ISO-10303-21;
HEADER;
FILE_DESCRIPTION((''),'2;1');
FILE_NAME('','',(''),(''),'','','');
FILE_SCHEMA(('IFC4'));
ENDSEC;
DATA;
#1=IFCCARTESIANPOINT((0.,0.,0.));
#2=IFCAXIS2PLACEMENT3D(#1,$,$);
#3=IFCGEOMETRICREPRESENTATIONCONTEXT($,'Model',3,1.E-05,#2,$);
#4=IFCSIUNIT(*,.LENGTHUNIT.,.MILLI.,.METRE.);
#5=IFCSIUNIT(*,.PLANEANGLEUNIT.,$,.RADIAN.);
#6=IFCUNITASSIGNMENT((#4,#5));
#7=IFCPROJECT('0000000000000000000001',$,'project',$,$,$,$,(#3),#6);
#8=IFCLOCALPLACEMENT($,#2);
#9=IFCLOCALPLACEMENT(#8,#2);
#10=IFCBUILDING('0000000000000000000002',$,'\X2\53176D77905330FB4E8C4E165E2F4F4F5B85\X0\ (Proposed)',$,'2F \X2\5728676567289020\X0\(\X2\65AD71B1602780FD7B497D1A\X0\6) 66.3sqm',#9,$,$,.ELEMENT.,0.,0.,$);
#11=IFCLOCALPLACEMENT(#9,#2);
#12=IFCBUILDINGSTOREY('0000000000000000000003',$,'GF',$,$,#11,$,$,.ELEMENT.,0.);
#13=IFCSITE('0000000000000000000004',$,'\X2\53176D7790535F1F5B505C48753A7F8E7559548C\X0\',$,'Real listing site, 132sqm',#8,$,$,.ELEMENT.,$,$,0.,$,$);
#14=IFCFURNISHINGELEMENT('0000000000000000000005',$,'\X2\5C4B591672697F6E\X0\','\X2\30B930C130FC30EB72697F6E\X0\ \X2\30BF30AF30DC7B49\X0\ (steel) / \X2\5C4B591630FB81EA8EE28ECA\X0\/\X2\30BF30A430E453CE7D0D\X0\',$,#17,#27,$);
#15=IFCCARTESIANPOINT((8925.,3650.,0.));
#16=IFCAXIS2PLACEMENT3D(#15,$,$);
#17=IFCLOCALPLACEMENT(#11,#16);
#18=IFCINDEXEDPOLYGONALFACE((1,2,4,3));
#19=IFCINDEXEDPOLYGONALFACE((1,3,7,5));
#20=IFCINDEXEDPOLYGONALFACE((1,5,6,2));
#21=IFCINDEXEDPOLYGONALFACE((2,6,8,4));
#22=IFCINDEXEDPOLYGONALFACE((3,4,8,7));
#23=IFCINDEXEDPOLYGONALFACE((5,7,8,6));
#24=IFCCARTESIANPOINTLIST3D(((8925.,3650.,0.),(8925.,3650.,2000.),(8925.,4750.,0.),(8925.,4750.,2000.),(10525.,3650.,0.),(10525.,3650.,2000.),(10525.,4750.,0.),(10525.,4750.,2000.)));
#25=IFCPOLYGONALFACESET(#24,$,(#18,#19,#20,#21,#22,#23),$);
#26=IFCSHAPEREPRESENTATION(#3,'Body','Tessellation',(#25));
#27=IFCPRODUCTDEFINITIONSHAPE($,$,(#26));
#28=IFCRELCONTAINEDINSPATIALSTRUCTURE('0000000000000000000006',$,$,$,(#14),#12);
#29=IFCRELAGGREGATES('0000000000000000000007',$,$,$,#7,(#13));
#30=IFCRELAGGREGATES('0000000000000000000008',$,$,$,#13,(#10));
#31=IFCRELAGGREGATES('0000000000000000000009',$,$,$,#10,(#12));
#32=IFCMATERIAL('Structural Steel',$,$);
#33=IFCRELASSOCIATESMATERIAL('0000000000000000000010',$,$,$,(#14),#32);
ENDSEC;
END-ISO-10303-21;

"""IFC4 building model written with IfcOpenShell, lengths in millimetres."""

from ifc_helpers import new_model, si_unit, frame, frame_2d, origin, place, context, project, spatial, rectangle, extrude, material, element, save


model = new_model("IFC4")

# Units and contexts
model_context = context("Model", 3, precision=1e-05, world=origin())
ifc_project = project(units=[si_unit("LENGTHUNIT", "METRE", prefix="MILLI"), si_unit("PLANEANGLEUNIT", "RADIAN")], contexts=[model_context])

# Site, building, storey
site_placement = place(None, origin())
site = spatial("IfcSite", under=ifc_project, at=site_placement, Name="北海道弟子屈町美留和", ObjectType="Real listing site, 132sqm", CompositionType="ELEMENT", RefElevation=0.0)
building_placement = place(site_placement, origin())
building = spatial("IfcBuilding", under=site, at=building_placement, Name="北海道・二世帯住宅 (Proposed)", ObjectType="2F 在来木造(断熱性能等級6) 66.3sqm", CompositionType="ELEMENT", ElevationOfRefHeight=0.0, ElevationOfTerrain=0.0)
storey_placement = place(building_placement, origin())
storey = spatial("IfcBuildingStorey", under=building, at=storey_placement, Name="GF", CompositionType="ELEMENT", Elevation=0.0)

# Shared definitions
ifc_material_1 = material(Name="Structural Steel")

# Furnishing element
furnishing_1_placement = place(storey_placement, frame((8925.0, 3650.0, 0.0)))
element("IfcFurnishingElement", 1, at=furnishing_1_placement, inside=storey, material=ifc_material_1, Name="屋外物置", Description="スチール物置 タクボ等 (steel) / 屋外・自転車/タイヤ収納", context=model_context, shape_type="SweptSolid", body=[
    extrude(rectangle(XDim=1600.0, YDim=1100.0, at=frame_2d((800.0, 550.0))), frame((8925.0, 3650.0, 0.0)), (0.0, 0.0, 1.0), 2000.0),
])

save(model, "model.ifc")
